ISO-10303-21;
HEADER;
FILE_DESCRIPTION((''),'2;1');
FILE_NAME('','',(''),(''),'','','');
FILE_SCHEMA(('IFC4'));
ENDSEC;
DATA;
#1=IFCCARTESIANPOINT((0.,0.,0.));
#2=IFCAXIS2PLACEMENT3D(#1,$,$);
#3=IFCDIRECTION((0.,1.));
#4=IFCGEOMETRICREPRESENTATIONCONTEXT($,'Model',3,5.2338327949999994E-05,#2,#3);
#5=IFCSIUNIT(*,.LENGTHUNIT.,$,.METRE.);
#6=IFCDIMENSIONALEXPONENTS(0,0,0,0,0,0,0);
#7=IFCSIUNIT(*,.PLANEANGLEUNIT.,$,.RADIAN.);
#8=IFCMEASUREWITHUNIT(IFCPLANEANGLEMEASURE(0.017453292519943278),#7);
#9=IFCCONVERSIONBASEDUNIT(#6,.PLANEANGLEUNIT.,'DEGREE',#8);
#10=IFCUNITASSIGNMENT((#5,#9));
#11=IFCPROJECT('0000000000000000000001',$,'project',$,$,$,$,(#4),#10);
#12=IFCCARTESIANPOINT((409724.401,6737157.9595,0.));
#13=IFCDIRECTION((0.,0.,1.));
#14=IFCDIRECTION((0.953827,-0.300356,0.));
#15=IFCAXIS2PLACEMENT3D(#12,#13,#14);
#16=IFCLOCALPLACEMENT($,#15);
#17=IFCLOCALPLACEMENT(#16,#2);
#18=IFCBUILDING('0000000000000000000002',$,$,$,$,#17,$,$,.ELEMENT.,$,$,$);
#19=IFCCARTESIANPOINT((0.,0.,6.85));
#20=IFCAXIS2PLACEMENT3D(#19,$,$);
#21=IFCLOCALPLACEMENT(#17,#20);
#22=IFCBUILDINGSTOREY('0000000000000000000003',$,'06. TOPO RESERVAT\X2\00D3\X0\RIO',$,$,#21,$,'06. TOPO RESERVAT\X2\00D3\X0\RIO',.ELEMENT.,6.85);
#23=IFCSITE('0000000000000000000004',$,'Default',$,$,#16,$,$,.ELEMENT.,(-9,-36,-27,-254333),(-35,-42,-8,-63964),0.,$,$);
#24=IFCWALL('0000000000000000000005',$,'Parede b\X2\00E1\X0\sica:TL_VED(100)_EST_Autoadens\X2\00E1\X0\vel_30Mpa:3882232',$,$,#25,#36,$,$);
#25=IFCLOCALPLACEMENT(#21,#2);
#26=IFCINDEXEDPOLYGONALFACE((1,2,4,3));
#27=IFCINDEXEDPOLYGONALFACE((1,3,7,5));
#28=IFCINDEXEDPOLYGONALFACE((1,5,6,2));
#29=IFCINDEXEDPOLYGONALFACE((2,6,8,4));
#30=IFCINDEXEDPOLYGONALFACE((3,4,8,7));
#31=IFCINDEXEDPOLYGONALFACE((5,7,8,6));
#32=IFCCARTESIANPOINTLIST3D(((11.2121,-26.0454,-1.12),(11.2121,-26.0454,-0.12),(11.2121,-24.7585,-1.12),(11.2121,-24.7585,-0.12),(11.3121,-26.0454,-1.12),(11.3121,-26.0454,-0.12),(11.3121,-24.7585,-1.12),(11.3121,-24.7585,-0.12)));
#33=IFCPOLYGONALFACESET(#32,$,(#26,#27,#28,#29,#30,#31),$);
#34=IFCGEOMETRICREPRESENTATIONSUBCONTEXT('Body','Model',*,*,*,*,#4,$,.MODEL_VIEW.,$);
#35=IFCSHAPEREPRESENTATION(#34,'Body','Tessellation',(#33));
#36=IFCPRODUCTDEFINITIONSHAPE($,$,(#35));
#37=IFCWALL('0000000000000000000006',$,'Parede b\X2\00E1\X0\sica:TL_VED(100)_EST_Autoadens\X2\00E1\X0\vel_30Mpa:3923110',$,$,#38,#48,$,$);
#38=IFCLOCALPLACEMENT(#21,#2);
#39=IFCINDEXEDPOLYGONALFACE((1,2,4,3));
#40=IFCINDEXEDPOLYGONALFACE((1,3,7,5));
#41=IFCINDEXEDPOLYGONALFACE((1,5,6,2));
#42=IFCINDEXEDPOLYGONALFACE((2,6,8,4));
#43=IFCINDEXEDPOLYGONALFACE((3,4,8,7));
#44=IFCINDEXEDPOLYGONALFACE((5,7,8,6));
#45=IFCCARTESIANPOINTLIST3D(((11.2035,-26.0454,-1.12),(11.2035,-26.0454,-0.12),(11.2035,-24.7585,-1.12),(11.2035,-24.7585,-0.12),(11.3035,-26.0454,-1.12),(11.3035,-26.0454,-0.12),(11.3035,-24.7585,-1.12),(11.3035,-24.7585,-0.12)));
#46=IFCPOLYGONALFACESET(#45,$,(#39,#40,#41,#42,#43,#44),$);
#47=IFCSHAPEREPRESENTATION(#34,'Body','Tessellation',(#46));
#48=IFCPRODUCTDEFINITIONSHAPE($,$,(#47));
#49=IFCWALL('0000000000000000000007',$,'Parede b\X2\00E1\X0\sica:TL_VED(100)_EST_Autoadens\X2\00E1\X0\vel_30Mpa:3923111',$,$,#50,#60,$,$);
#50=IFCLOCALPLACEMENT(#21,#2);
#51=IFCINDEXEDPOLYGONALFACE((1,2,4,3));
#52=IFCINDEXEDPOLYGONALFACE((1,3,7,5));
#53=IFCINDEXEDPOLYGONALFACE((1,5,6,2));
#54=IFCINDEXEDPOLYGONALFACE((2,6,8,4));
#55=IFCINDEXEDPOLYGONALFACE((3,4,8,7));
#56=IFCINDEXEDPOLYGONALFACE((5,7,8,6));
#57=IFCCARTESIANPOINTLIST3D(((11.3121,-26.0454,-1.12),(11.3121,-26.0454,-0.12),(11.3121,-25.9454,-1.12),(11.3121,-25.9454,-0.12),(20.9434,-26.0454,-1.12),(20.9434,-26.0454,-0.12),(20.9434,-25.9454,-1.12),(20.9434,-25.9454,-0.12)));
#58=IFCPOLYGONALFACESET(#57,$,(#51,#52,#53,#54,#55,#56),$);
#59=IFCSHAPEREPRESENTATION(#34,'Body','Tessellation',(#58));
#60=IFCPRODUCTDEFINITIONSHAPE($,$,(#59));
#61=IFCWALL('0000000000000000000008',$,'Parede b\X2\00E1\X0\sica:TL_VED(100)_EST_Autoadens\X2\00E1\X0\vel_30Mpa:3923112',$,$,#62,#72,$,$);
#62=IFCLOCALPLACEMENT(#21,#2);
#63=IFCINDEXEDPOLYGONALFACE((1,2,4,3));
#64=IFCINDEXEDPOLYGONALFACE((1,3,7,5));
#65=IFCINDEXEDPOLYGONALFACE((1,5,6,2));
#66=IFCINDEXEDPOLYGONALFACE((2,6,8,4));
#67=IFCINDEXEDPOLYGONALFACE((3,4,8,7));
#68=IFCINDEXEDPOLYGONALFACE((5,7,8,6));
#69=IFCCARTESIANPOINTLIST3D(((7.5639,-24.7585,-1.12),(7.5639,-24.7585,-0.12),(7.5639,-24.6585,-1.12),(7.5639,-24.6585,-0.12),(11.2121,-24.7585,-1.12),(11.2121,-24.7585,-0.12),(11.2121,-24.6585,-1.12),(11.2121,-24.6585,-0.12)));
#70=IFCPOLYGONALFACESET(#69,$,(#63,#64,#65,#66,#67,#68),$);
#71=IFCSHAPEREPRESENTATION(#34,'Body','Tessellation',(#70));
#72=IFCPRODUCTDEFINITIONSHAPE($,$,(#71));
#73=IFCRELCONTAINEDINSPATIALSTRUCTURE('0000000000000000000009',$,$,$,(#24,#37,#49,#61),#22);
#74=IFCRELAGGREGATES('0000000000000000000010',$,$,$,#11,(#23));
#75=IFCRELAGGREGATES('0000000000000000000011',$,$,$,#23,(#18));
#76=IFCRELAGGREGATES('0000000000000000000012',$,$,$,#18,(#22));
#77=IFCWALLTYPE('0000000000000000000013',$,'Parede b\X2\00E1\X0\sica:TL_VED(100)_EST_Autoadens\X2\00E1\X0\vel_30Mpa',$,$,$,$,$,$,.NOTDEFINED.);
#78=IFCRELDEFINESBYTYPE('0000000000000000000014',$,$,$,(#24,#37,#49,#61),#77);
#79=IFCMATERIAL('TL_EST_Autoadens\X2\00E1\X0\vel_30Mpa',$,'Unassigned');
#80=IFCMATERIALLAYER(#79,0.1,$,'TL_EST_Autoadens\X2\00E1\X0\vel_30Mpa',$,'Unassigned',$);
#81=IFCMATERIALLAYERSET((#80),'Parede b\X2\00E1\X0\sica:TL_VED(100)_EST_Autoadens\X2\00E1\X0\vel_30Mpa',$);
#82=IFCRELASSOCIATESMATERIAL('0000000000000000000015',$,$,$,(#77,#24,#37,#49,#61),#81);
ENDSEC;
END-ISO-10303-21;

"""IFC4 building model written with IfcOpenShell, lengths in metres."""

from ifc_helpers import new_model, entity, si_unit, converted_unit, direction, frame, frame_2d, origin, place, context, subcontext, project, spatial, rectangle, extrude, material, layer, layer_set, layer_usage, type_object, element, save


model = new_model("IFC4")

# Units and contexts
model_context = context("Model", 3, precision=5.2338327949999994e-05, world=origin(), true_north=direction((0.0, 1.0)))
body_context = subcontext(model_context, "Body", "Model", "MODEL_VIEW")
ifc_project = project(units=[si_unit("LENGTHUNIT", "METRE"), converted_unit("PLANEANGLEUNIT", "DEGREE", entity("IfcPlaneAngleMeasure", 0.017453292519943278), si_unit("PLANEANGLEUNIT", "RADIAN"), dimensions=[0, 0, 0, 0, 0, 0, 0])], contexts=[model_context])

# Site, building, storey
site_placement = place(None, frame((409724.401, 6737157.9595, 0.0), z_axis=(0.0, 0.0, 1.0), x_axis=(0.953827, -0.300356, 0.0)))
site = spatial("IfcSite", under=ifc_project, at=site_placement, Name="Default", CompositionType="ELEMENT", RefLatitude=(-9, -36, -27, -254333), RefLongitude=(-35, -42, -8, -63964), RefElevation=0.0)
building_placement = place(site_placement, origin())
building = spatial("IfcBuilding", under=site, at=building_placement, CompositionType="ELEMENT")
storey_placement = place(building_placement, frame((0.0, 0.0, 6.85)))
storey = spatial("IfcBuildingStorey", under=building, at=storey_placement, Name="06. TOPO RESERVATÓRIO", LongName="06. TOPO RESERVATÓRIO", CompositionType="ELEMENT", Elevation=6.85)

# Walls
ifc_material_1 = material(Name="TL_EST_Autoadensável_30Mpa", Category="Unassigned")
ifc_layer = layer(ifc_material_1, 0.1, Name="TL_EST_Autoadensável_30Mpa", Category="Unassigned")
ifc_layer_set = layer_set([ifc_layer], Name="Parede básica:TL_VED(100)_EST_Autoadensável_30Mpa")
ifc_layer_usage_1 = layer_usage(ifc_layer_set, "AXIS2", "NEGATIVE", 0.05)
wall_type = type_object("IfcWallType", Name="Parede básica:TL_VED(100)_EST_Autoadensável_30Mpa", PredefinedType="NOTDEFINED", material=ifc_layer_set)
wall_1_placement = place(storey_placement, frame((11.2621, -24.7585, -1.12), z_axis=(0.0, 0.0, 1.0), x_axis=(0.0, -1.0, 0.0)))
element("IfcWall", 1, at=wall_1_placement, inside=storey, type_object=wall_type, material=ifc_layer_usage_1, Name="Parede básica:TL_VED(100)_EST_Autoadensável_30Mpa:3882232", context=body_context, shape_type="SweptSolid", body=[
    extrude(rectangle(XDim=1.2869, YDim=0.1, at=frame_2d((0.6434, 0.0), x_axis=(-1.0, 0.0))), origin(), (0.0, 0.0, 1.0), 1.0),
])
ifc_layer_usage_2 = layer_usage(ifc_layer_set, "AXIS2", "NEGATIVE", 0.05)
wall_2_placement = place(storey_placement, frame((11.2535, -24.7585, -1.12), z_axis=(0.0, 0.0, 1.0), x_axis=(0.0, -1.0, 0.0)))
element("IfcWall", 2, at=wall_2_placement, inside=storey, type_object=wall_type, material=ifc_layer_usage_2, Name="Parede básica:TL_VED(100)_EST_Autoadensável_30Mpa:3923110", context=body_context, shape_type="SweptSolid", body=[
    extrude(rectangle(XDim=1.2869, YDim=0.1, at=frame_2d((0.6434, 0.0), x_axis=(-1.0, 0.0))), origin(), (0.0, 0.0, 1.0), 1.0),
])
ifc_layer_usage_3 = layer_usage(ifc_layer_set, "AXIS2", "NEGATIVE", 0.05)
wall_3_placement = place(storey_placement, frame((11.3121, -25.9954, -1.12)))
element("IfcWall", 3, at=wall_3_placement, inside=storey, type_object=wall_type, material=ifc_layer_usage_3, Name="Parede básica:TL_VED(100)_EST_Autoadensável_30Mpa:3923111", context=body_context, shape_type="SweptSolid", body=[
    extrude(rectangle(XDim=9.6313, YDim=0.1, at=frame_2d((4.8156, 0.0), x_axis=(-1.0, 0.0))), origin(), (0.0, 0.0, 1.0), 1.0),
])
ifc_layer_usage_4 = layer_usage(ifc_layer_set, "AXIS2", "NEGATIVE", 0.05)
wall_4_placement = place(storey_placement, frame((11.2121, -24.7085, -1.12), z_axis=(0.0, 0.0, 1.0), x_axis=(-1.0, 0.0, 0.0)))
element("IfcWall", 4, at=wall_4_placement, inside=storey, type_object=wall_type, material=ifc_layer_usage_4, Name="Parede básica:TL_VED(100)_EST_Autoadensável_30Mpa:3923112", context=body_context, shape_type="SweptSolid", body=[
    extrude(rectangle(XDim=3.6482, YDim=0.1, at=frame_2d((1.8241, 0.0), x_axis=(-1.0, 0.0))), origin(), (0.0, 0.0, 1.0), 1.0),
])

save(model, "model.ifc")
